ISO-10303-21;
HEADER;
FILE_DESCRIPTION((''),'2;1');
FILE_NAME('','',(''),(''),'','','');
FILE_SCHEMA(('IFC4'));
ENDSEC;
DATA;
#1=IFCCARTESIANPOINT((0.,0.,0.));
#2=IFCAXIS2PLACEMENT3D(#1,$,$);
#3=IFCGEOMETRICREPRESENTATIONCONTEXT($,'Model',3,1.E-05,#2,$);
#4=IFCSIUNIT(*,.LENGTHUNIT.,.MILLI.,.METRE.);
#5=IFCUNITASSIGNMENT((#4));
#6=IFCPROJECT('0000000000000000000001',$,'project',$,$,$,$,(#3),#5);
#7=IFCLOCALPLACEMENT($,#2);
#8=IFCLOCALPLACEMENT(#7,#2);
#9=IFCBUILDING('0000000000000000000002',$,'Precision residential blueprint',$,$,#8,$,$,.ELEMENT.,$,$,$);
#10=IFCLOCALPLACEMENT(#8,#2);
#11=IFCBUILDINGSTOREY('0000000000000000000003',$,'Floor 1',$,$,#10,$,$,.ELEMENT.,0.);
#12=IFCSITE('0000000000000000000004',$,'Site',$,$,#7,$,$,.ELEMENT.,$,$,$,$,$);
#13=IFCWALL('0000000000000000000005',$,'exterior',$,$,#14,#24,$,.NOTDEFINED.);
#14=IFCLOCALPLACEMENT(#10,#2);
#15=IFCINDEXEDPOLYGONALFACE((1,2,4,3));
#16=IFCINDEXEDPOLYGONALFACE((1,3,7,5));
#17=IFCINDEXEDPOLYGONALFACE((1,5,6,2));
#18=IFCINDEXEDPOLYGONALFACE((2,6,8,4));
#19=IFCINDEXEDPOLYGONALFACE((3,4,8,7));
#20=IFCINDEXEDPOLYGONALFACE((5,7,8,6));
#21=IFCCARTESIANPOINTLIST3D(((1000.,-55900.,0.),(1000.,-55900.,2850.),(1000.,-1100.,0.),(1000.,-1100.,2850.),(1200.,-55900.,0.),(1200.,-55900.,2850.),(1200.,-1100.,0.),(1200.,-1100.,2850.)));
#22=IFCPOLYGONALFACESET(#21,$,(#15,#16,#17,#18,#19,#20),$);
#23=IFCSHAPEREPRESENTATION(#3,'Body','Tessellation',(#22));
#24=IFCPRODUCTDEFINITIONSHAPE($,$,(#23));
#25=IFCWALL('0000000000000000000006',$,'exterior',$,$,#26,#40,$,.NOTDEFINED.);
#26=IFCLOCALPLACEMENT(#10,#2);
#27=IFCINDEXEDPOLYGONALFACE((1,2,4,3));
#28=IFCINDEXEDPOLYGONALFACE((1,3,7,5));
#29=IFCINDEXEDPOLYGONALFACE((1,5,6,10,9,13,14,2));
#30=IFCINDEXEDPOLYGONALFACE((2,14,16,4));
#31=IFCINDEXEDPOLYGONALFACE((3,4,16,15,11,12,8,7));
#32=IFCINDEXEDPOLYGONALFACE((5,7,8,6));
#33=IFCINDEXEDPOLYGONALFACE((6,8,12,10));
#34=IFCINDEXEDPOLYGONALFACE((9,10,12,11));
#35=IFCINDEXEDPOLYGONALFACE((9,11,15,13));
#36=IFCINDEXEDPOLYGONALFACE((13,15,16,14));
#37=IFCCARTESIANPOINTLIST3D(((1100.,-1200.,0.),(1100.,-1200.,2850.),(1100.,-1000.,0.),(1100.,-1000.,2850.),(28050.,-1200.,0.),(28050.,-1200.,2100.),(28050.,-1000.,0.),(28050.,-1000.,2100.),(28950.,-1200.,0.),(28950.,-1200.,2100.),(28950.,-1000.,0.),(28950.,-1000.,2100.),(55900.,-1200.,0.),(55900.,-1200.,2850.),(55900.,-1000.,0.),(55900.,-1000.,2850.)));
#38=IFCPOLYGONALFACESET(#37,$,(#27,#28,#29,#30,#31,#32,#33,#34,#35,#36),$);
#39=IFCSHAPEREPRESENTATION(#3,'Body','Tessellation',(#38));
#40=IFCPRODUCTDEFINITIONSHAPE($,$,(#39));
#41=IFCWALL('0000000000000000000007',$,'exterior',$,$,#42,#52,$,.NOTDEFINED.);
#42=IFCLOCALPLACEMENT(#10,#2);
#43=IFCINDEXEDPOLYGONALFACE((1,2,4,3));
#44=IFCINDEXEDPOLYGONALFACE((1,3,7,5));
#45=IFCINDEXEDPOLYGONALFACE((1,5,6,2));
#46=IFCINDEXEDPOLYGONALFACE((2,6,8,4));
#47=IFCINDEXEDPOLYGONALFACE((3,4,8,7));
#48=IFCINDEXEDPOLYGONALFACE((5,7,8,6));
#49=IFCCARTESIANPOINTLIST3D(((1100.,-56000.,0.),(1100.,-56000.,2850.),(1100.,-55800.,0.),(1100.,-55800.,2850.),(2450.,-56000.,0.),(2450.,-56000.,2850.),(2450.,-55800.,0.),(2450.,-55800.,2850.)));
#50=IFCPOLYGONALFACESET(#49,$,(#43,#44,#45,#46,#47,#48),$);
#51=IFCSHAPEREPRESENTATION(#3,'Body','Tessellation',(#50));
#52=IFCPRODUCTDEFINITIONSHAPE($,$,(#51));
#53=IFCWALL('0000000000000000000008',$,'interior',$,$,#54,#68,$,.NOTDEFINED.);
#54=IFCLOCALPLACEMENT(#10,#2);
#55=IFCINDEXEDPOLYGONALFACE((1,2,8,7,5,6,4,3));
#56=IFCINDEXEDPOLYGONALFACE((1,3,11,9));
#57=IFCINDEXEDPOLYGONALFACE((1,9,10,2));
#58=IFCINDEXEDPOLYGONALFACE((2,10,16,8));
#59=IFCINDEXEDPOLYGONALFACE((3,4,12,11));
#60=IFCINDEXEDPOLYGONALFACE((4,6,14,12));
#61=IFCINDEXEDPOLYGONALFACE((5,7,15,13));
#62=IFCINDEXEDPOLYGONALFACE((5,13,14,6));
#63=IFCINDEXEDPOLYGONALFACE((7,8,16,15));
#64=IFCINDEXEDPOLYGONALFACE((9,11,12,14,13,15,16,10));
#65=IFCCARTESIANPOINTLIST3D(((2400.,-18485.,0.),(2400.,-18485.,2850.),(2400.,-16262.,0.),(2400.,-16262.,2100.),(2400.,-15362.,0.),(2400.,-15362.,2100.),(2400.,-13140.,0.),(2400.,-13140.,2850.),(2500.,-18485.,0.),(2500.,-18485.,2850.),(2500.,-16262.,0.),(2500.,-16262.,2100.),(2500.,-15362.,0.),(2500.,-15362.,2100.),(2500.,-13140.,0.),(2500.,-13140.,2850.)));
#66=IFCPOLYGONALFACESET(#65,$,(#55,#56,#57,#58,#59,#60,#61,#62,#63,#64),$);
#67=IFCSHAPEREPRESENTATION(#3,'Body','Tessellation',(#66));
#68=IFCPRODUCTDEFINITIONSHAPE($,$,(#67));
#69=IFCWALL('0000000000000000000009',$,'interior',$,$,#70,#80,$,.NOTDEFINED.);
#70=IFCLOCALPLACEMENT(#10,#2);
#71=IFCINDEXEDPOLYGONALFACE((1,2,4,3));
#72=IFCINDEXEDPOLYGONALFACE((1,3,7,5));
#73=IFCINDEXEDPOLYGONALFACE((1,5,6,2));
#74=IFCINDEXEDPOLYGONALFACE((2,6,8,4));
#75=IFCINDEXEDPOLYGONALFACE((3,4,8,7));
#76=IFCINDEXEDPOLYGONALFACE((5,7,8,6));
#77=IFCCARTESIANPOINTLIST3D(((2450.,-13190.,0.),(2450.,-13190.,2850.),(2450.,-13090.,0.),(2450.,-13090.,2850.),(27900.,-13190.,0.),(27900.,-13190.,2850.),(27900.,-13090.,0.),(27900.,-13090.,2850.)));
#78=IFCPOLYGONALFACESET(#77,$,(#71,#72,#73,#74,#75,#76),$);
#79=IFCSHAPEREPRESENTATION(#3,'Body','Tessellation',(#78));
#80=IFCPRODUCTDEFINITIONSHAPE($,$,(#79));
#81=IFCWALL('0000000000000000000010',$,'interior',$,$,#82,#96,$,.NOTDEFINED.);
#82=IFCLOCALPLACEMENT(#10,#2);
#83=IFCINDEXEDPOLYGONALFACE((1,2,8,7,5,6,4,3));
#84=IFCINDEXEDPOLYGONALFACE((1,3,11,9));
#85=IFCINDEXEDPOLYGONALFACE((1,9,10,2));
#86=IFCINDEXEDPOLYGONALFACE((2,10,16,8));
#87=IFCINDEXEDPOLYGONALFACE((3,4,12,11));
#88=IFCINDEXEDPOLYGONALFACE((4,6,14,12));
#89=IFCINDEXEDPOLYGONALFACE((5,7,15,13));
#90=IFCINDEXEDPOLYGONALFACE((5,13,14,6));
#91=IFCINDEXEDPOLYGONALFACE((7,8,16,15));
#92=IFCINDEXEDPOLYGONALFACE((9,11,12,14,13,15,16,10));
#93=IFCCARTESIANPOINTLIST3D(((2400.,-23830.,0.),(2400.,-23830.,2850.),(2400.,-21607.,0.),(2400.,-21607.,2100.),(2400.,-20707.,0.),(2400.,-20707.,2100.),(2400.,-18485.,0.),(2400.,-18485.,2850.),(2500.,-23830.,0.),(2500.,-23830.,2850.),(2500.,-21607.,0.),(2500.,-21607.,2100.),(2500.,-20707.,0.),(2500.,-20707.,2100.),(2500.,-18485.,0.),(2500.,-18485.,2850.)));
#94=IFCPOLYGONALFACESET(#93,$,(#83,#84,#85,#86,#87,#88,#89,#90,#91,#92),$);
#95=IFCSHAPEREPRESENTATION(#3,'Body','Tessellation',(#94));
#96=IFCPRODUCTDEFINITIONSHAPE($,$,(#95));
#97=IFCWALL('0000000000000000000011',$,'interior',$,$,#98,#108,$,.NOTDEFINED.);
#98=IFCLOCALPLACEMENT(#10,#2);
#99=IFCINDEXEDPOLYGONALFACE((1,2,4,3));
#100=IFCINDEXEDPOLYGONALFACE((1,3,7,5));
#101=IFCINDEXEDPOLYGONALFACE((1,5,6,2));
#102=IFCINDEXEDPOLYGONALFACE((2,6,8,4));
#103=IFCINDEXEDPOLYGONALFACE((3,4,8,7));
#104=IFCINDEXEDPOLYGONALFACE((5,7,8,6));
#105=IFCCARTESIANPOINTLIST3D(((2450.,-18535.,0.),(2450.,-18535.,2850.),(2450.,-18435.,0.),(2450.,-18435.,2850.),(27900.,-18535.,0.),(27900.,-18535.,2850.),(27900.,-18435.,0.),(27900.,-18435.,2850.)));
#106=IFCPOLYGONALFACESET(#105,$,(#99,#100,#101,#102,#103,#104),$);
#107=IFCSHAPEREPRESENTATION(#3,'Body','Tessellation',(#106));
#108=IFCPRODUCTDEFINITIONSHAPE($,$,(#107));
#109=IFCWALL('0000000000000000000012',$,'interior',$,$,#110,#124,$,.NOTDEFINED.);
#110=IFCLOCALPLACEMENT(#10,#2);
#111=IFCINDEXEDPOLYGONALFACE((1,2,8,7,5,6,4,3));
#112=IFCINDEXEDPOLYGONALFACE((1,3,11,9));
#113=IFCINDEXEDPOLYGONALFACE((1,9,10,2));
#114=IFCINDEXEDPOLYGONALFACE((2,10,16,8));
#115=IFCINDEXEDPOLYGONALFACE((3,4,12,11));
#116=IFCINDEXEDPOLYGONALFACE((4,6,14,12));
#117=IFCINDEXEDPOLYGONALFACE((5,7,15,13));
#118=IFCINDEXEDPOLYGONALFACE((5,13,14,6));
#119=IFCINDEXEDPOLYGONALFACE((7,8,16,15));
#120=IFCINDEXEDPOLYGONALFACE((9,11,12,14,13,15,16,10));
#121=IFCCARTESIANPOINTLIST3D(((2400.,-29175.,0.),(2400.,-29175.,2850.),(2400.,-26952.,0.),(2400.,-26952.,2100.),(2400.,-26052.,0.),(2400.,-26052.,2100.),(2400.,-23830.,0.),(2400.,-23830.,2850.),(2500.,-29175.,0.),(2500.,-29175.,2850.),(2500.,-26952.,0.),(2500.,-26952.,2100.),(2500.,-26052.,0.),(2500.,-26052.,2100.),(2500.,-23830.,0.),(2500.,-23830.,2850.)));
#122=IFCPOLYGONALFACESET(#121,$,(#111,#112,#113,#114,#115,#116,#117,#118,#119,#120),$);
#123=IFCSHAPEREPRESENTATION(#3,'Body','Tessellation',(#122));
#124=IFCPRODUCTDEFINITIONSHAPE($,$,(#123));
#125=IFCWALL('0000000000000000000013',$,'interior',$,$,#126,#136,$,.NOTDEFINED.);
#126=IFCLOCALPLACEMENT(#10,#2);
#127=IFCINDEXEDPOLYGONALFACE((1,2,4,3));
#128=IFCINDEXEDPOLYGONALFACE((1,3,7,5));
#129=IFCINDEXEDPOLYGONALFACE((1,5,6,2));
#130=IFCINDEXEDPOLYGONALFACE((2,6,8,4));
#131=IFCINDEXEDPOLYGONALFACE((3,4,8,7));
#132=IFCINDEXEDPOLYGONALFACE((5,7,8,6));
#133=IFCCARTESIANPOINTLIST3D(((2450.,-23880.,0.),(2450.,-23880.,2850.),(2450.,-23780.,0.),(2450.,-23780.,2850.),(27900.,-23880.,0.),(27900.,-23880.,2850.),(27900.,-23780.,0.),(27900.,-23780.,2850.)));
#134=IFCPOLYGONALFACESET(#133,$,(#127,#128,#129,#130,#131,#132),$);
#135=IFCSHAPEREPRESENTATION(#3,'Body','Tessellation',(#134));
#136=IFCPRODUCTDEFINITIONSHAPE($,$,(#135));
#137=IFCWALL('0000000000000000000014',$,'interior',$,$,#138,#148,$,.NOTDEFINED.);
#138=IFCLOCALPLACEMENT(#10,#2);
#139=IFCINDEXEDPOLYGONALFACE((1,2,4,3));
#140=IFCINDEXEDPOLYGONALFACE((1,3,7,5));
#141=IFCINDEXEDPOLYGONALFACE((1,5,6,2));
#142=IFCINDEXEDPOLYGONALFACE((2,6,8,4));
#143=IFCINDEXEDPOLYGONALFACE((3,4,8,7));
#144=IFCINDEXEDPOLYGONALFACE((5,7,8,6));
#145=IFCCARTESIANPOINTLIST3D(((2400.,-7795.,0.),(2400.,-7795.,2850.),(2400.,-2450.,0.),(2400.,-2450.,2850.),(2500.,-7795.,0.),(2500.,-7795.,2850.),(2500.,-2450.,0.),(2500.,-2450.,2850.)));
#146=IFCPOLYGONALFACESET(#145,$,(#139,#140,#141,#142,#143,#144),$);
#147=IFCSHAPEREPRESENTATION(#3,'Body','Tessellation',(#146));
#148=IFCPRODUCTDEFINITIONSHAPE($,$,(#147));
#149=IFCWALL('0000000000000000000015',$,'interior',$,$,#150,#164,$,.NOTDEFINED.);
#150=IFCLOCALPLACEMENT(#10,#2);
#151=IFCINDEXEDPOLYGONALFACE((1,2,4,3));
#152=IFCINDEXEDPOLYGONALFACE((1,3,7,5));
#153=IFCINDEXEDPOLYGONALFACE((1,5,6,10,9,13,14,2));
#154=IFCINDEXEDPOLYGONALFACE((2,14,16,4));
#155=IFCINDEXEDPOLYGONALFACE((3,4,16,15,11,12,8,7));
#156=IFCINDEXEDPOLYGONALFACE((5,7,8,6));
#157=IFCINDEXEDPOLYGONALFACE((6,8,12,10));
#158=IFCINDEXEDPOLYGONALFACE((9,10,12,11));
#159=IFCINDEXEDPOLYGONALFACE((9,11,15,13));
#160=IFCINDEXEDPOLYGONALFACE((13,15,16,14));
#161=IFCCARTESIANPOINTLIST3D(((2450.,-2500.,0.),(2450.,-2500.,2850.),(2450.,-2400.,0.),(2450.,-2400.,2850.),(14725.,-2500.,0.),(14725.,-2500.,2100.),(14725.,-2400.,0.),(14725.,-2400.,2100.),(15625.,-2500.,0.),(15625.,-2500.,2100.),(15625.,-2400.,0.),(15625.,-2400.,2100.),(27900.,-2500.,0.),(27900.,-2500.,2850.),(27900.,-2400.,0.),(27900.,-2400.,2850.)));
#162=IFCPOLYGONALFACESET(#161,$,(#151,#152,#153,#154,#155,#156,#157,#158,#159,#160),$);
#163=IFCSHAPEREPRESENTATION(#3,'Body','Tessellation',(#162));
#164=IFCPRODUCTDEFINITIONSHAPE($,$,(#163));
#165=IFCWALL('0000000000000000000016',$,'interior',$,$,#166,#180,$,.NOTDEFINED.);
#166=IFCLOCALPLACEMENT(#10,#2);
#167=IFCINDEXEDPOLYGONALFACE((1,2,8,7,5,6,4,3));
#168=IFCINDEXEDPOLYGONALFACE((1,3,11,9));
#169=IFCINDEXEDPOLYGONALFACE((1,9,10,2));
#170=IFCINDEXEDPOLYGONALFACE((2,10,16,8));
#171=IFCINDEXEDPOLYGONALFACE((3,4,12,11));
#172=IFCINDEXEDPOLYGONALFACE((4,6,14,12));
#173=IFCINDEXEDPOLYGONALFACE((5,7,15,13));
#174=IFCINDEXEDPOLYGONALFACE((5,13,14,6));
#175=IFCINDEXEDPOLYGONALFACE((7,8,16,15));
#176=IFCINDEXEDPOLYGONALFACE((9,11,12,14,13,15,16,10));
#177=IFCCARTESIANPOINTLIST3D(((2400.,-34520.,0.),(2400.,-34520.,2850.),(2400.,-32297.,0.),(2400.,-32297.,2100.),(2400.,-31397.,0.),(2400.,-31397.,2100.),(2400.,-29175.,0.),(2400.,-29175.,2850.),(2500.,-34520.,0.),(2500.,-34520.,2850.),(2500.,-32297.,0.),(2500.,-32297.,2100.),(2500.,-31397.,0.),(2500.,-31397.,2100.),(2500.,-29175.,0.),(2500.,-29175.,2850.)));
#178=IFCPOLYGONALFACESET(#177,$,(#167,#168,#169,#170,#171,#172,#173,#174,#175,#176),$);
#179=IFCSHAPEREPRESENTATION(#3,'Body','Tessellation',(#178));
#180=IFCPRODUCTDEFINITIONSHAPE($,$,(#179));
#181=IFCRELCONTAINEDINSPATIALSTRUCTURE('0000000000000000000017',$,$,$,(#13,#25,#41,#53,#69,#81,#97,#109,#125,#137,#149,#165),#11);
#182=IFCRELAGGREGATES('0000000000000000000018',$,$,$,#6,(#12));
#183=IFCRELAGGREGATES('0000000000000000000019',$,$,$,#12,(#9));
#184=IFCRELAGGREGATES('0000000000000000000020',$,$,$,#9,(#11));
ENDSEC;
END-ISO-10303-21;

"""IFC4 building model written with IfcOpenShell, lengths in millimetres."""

from ifc_helpers import new_model, si_unit, origin, place, context, project, spatial, polyline, outline, extrude, element, save


model = new_model("IFC4")

# Units and contexts
model_context = context("Model", 3, precision=1e-05, world=origin())
ifc_project = project(units=[si_unit("LENGTHUNIT", "METRE", prefix="MILLI")], contexts=[model_context])

# Site, building, storey
site_placement = place(None, origin())
site = spatial("IfcSite", under=ifc_project, at=site_placement, Name="Site", CompositionType="ELEMENT")
building_placement = place(site_placement, origin())
building = spatial("IfcBuilding", under=site, at=building_placement, Name="Precision residential blueprint", CompositionType="ELEMENT")
storey_placement = place(building_placement, origin())
storey = spatial("IfcBuildingStorey", under=building, at=storey_placement, Name="Floor 1", CompositionType="ELEMENT", Elevation=0.0)

# Wall
wall_1_placement = place(storey_placement, origin())
element("IfcWall", 1, at=wall_1_placement, inside=storey, Name="exterior", PredefinedType="NOTDEFINED", context=model_context, shape_type="SweptSolid", body=[
    extrude(outline(polyline([(1200.0, -1100.0), (1200.0, -55900.0), (1000.0, -55900.0), (1000.0, -1100.0), (1200.0, -1100.0)])), origin(), (0.0, 0.0, 1.0), 2850.0),
])

# Wall, opening
wall_2_placement = place(storey_placement, origin())
wall_2 = element("IfcWall", 2, at=wall_2_placement, inside=storey, Name="exterior", PredefinedType="NOTDEFINED", context=model_context, shape_type="SweptSolid", body=[
    extrude(outline(polyline([(1100.0, -1000.0), (55900.0, -1000.0), (55900.0, -1200.0), (1100.0, -1200.0), (1100.0, -1000.0)])), origin(), (0.0, 0.0, 1.0), 2850.0),
])
opening_1_placement = place(storey_placement, origin())
element("IfcOpeningElement", 3, at=opening_1_placement, cuts=wall_2, PredefinedType="OPENING", context=model_context, shape_type="SweptSolid", body=[
    extrude(outline(polyline([(28050.0, -1000.0), (28950.0, -1000.0), (28950.0, -1200.0), (28050.0, -1200.0), (28050.0, -1000.0)])), origin(), (0.0, 0.0, 1.0), 2100.0),
])

# Wall
wall_3_placement = place(storey_placement, origin())
element("IfcWall", 4, at=wall_3_placement, inside=storey, Name="exterior", PredefinedType="NOTDEFINED", context=model_context, shape_type="SweptSolid", body=[
    extrude(outline(polyline([(1100.0, -55800.0), (2450.0, -55800.0), (2450.0, -56000.0), (1100.0, -56000.0), (1100.0, -55800.0)])), origin(), (0.0, 0.0, 1.0), 2850.0),
])

# Wall, opening
wall_4_placement = place(storey_placement, origin())
wall_4 = element("IfcWall", 5, at=wall_4_placement, inside=storey, Name="interior", PredefinedType="NOTDEFINED", context=model_context, shape_type="SweptSolid", body=[
    extrude(outline(polyline([(2500.0, -13140.0), (2500.0, -18485.0), (2400.0, -18485.0), (2400.0, -13140.0), (2500.0, -13140.0)])), origin(), (0.0, 0.0, 1.0), 2850.0),
])
opening_2_placement = place(storey_placement, origin())
element("IfcOpeningElement", 6, at=opening_2_placement, cuts=wall_4, PredefinedType="OPENING", context=model_context, shape_type="SweptSolid", body=[
    extrude(outline(polyline([(2500.0, -15362.0), (2500.0, -16262.0), (2400.0, -16262.0), (2400.0, -15362.0), (2500.0, -15362.0)])), origin(), (0.0, 0.0, 1.0), 2100.0),
])

# Wall
wall_5_placement = place(storey_placement, origin())
element("IfcWall", 7, at=wall_5_placement, inside=storey, Name="interior", PredefinedType="NOTDEFINED", context=model_context, shape_type="SweptSolid", body=[
    extrude(outline(polyline([(2450.0, -13090.0), (27900.0, -13090.0), (27900.0, -13190.0), (2450.0, -13190.0), (2450.0, -13090.0)])), origin(), (0.0, 0.0, 1.0), 2850.0),
])

# Wall, opening
wall_6_placement = place(storey_placement, origin())
wall_6 = element("IfcWall", 8, at=wall_6_placement, inside=storey, Name="interior", PredefinedType="NOTDEFINED", context=model_context, shape_type="SweptSolid", body=[
    extrude(outline(polyline([(2500.0, -18485.0), (2500.0, -23830.0), (2400.0, -23830.0), (2400.0, -18485.0), (2500.0, -18485.0)])), origin(), (0.0, 0.0, 1.0), 2850.0),
])
opening_3_placement = place(storey_placement, origin())
element("IfcOpeningElement", 9, at=opening_3_placement, cuts=wall_6, PredefinedType="OPENING", context=model_context, shape_type="SweptSolid", body=[
    extrude(outline(polyline([(2500.0, -20707.0), (2500.0, -21607.0), (2400.0, -21607.0), (2400.0, -20707.0), (2500.0, -20707.0)])), origin(), (0.0, 0.0, 1.0), 2100.0),
])

# Wall
wall_7_placement = place(storey_placement, origin())
element("IfcWall", 10, at=wall_7_placement, inside=storey, Name="interior", PredefinedType="NOTDEFINED", context=model_context, shape_type="SweptSolid", body=[
    extrude(outline(polyline([(2450.0, -18435.0), (27900.0, -18435.0), (27900.0, -18535.0), (2450.0, -18535.0), (2450.0, -18435.0)])), origin(), (0.0, 0.0, 1.0), 2850.0),
])

# Wall, opening
wall_8_placement = place(storey_placement, origin())
wall_8 = element("IfcWall", 11, at=wall_8_placement, inside=storey, Name="interior", PredefinedType="NOTDEFINED", context=model_context, shape_type="SweptSolid", body=[
    extrude(outline(polyline([(2500.0, -23830.0), (2500.0, -29175.0), (2400.0, -29175.0), (2400.0, -23830.0), (2500.0, -23830.0)])), origin(), (0.0, 0.0, 1.0), 2850.0),
])
opening_4_placement = place(storey_placement, origin())
element("IfcOpeningElement", 12, at=opening_4_placement, cuts=wall_8, PredefinedType="OPENING", context=model_context, shape_type="SweptSolid", body=[
    extrude(outline(polyline([(2500.0, -26052.0), (2500.0, -26952.0), (2400.0, -26952.0), (2400.0, -26052.0), (2500.0, -26052.0)])), origin(), (0.0, 0.0, 1.0), 2100.0),
])

# Walls
wall_9_placement = place(storey_placement, origin())
element("IfcWall", 13, at=wall_9_placement, inside=storey, Name="interior", PredefinedType="NOTDEFINED", context=model_context, shape_type="SweptSolid", body=[
    extrude(outline(polyline([(2450.0, -23780.0), (27900.0, -23780.0), (27900.0, -23880.0), (2450.0, -23880.0), (2450.0, -23780.0)])), origin(), (0.0, 0.0, 1.0), 2850.0),
])
wall_10_placement = place(storey_placement, origin())
element("IfcWall", 14, at=wall_10_placement, inside=storey, Name="interior", PredefinedType="NOTDEFINED", context=model_context, shape_type="SweptSolid", body=[
    extrude(outline(polyline([(2500.0, -2450.0), (2500.0, -7795.0), (2400.0, -7795.0), (2400.0, -2450.0), (2500.0, -2450.0)])), origin(), (0.0, 0.0, 1.0), 2850.0),
])

# Walls, openings
wall_11_placement = place(storey_placement, origin())
wall_11 = element("IfcWall", 15, at=wall_11_placement, inside=storey, Name="interior", PredefinedType="NOTDEFINED", context=model_context, shape_type="SweptSolid", body=[
    extrude(outline(polyline([(2450.0, -2400.0), (27900.0, -2400.0), (27900.0, -2500.0), (2450.0, -2500.0), (2450.0, -2400.0)])), origin(), (0.0, 0.0, 1.0), 2850.0),
])
opening_5_placement = place(storey_placement, origin())
element("IfcOpeningElement", 16, at=opening_5_placement, cuts=wall_11, PredefinedType="OPENING", context=model_context, shape_type="SweptSolid", body=[
    extrude(outline(polyline([(14725.0, -2400.0), (15625.0, -2400.0), (15625.0, -2500.0), (14725.0, -2500.0), (14725.0, -2400.0)])), origin(), (0.0, 0.0, 1.0), 2100.0),
])
wall_12_placement = place(storey_placement, origin())
wall_12 = element("IfcWall", 17, at=wall_12_placement, inside=storey, Name="interior", PredefinedType="NOTDEFINED", context=model_context, shape_type="SweptSolid", body=[
    extrude(outline(polyline([(2500.0, -29175.0), (2500.0, -34520.0), (2400.0, -34520.0), (2400.0, -29175.0), (2500.0, -29175.0)])), origin(), (0.0, 0.0, 1.0), 2850.0),
])
opening_6_placement = place(storey_placement, origin())
element("IfcOpeningElement", 18, at=opening_6_placement, cuts=wall_12, PredefinedType="OPENING", context=model_context, shape_type="SweptSolid", body=[
    extrude(outline(polyline([(2500.0, -31397.0), (2500.0, -32297.0), (2400.0, -32297.0), (2400.0, -31397.0), (2500.0, -31397.0)])), origin(), (0.0, 0.0, 1.0), 2100.0),
])

save(model, "model.ifc")
